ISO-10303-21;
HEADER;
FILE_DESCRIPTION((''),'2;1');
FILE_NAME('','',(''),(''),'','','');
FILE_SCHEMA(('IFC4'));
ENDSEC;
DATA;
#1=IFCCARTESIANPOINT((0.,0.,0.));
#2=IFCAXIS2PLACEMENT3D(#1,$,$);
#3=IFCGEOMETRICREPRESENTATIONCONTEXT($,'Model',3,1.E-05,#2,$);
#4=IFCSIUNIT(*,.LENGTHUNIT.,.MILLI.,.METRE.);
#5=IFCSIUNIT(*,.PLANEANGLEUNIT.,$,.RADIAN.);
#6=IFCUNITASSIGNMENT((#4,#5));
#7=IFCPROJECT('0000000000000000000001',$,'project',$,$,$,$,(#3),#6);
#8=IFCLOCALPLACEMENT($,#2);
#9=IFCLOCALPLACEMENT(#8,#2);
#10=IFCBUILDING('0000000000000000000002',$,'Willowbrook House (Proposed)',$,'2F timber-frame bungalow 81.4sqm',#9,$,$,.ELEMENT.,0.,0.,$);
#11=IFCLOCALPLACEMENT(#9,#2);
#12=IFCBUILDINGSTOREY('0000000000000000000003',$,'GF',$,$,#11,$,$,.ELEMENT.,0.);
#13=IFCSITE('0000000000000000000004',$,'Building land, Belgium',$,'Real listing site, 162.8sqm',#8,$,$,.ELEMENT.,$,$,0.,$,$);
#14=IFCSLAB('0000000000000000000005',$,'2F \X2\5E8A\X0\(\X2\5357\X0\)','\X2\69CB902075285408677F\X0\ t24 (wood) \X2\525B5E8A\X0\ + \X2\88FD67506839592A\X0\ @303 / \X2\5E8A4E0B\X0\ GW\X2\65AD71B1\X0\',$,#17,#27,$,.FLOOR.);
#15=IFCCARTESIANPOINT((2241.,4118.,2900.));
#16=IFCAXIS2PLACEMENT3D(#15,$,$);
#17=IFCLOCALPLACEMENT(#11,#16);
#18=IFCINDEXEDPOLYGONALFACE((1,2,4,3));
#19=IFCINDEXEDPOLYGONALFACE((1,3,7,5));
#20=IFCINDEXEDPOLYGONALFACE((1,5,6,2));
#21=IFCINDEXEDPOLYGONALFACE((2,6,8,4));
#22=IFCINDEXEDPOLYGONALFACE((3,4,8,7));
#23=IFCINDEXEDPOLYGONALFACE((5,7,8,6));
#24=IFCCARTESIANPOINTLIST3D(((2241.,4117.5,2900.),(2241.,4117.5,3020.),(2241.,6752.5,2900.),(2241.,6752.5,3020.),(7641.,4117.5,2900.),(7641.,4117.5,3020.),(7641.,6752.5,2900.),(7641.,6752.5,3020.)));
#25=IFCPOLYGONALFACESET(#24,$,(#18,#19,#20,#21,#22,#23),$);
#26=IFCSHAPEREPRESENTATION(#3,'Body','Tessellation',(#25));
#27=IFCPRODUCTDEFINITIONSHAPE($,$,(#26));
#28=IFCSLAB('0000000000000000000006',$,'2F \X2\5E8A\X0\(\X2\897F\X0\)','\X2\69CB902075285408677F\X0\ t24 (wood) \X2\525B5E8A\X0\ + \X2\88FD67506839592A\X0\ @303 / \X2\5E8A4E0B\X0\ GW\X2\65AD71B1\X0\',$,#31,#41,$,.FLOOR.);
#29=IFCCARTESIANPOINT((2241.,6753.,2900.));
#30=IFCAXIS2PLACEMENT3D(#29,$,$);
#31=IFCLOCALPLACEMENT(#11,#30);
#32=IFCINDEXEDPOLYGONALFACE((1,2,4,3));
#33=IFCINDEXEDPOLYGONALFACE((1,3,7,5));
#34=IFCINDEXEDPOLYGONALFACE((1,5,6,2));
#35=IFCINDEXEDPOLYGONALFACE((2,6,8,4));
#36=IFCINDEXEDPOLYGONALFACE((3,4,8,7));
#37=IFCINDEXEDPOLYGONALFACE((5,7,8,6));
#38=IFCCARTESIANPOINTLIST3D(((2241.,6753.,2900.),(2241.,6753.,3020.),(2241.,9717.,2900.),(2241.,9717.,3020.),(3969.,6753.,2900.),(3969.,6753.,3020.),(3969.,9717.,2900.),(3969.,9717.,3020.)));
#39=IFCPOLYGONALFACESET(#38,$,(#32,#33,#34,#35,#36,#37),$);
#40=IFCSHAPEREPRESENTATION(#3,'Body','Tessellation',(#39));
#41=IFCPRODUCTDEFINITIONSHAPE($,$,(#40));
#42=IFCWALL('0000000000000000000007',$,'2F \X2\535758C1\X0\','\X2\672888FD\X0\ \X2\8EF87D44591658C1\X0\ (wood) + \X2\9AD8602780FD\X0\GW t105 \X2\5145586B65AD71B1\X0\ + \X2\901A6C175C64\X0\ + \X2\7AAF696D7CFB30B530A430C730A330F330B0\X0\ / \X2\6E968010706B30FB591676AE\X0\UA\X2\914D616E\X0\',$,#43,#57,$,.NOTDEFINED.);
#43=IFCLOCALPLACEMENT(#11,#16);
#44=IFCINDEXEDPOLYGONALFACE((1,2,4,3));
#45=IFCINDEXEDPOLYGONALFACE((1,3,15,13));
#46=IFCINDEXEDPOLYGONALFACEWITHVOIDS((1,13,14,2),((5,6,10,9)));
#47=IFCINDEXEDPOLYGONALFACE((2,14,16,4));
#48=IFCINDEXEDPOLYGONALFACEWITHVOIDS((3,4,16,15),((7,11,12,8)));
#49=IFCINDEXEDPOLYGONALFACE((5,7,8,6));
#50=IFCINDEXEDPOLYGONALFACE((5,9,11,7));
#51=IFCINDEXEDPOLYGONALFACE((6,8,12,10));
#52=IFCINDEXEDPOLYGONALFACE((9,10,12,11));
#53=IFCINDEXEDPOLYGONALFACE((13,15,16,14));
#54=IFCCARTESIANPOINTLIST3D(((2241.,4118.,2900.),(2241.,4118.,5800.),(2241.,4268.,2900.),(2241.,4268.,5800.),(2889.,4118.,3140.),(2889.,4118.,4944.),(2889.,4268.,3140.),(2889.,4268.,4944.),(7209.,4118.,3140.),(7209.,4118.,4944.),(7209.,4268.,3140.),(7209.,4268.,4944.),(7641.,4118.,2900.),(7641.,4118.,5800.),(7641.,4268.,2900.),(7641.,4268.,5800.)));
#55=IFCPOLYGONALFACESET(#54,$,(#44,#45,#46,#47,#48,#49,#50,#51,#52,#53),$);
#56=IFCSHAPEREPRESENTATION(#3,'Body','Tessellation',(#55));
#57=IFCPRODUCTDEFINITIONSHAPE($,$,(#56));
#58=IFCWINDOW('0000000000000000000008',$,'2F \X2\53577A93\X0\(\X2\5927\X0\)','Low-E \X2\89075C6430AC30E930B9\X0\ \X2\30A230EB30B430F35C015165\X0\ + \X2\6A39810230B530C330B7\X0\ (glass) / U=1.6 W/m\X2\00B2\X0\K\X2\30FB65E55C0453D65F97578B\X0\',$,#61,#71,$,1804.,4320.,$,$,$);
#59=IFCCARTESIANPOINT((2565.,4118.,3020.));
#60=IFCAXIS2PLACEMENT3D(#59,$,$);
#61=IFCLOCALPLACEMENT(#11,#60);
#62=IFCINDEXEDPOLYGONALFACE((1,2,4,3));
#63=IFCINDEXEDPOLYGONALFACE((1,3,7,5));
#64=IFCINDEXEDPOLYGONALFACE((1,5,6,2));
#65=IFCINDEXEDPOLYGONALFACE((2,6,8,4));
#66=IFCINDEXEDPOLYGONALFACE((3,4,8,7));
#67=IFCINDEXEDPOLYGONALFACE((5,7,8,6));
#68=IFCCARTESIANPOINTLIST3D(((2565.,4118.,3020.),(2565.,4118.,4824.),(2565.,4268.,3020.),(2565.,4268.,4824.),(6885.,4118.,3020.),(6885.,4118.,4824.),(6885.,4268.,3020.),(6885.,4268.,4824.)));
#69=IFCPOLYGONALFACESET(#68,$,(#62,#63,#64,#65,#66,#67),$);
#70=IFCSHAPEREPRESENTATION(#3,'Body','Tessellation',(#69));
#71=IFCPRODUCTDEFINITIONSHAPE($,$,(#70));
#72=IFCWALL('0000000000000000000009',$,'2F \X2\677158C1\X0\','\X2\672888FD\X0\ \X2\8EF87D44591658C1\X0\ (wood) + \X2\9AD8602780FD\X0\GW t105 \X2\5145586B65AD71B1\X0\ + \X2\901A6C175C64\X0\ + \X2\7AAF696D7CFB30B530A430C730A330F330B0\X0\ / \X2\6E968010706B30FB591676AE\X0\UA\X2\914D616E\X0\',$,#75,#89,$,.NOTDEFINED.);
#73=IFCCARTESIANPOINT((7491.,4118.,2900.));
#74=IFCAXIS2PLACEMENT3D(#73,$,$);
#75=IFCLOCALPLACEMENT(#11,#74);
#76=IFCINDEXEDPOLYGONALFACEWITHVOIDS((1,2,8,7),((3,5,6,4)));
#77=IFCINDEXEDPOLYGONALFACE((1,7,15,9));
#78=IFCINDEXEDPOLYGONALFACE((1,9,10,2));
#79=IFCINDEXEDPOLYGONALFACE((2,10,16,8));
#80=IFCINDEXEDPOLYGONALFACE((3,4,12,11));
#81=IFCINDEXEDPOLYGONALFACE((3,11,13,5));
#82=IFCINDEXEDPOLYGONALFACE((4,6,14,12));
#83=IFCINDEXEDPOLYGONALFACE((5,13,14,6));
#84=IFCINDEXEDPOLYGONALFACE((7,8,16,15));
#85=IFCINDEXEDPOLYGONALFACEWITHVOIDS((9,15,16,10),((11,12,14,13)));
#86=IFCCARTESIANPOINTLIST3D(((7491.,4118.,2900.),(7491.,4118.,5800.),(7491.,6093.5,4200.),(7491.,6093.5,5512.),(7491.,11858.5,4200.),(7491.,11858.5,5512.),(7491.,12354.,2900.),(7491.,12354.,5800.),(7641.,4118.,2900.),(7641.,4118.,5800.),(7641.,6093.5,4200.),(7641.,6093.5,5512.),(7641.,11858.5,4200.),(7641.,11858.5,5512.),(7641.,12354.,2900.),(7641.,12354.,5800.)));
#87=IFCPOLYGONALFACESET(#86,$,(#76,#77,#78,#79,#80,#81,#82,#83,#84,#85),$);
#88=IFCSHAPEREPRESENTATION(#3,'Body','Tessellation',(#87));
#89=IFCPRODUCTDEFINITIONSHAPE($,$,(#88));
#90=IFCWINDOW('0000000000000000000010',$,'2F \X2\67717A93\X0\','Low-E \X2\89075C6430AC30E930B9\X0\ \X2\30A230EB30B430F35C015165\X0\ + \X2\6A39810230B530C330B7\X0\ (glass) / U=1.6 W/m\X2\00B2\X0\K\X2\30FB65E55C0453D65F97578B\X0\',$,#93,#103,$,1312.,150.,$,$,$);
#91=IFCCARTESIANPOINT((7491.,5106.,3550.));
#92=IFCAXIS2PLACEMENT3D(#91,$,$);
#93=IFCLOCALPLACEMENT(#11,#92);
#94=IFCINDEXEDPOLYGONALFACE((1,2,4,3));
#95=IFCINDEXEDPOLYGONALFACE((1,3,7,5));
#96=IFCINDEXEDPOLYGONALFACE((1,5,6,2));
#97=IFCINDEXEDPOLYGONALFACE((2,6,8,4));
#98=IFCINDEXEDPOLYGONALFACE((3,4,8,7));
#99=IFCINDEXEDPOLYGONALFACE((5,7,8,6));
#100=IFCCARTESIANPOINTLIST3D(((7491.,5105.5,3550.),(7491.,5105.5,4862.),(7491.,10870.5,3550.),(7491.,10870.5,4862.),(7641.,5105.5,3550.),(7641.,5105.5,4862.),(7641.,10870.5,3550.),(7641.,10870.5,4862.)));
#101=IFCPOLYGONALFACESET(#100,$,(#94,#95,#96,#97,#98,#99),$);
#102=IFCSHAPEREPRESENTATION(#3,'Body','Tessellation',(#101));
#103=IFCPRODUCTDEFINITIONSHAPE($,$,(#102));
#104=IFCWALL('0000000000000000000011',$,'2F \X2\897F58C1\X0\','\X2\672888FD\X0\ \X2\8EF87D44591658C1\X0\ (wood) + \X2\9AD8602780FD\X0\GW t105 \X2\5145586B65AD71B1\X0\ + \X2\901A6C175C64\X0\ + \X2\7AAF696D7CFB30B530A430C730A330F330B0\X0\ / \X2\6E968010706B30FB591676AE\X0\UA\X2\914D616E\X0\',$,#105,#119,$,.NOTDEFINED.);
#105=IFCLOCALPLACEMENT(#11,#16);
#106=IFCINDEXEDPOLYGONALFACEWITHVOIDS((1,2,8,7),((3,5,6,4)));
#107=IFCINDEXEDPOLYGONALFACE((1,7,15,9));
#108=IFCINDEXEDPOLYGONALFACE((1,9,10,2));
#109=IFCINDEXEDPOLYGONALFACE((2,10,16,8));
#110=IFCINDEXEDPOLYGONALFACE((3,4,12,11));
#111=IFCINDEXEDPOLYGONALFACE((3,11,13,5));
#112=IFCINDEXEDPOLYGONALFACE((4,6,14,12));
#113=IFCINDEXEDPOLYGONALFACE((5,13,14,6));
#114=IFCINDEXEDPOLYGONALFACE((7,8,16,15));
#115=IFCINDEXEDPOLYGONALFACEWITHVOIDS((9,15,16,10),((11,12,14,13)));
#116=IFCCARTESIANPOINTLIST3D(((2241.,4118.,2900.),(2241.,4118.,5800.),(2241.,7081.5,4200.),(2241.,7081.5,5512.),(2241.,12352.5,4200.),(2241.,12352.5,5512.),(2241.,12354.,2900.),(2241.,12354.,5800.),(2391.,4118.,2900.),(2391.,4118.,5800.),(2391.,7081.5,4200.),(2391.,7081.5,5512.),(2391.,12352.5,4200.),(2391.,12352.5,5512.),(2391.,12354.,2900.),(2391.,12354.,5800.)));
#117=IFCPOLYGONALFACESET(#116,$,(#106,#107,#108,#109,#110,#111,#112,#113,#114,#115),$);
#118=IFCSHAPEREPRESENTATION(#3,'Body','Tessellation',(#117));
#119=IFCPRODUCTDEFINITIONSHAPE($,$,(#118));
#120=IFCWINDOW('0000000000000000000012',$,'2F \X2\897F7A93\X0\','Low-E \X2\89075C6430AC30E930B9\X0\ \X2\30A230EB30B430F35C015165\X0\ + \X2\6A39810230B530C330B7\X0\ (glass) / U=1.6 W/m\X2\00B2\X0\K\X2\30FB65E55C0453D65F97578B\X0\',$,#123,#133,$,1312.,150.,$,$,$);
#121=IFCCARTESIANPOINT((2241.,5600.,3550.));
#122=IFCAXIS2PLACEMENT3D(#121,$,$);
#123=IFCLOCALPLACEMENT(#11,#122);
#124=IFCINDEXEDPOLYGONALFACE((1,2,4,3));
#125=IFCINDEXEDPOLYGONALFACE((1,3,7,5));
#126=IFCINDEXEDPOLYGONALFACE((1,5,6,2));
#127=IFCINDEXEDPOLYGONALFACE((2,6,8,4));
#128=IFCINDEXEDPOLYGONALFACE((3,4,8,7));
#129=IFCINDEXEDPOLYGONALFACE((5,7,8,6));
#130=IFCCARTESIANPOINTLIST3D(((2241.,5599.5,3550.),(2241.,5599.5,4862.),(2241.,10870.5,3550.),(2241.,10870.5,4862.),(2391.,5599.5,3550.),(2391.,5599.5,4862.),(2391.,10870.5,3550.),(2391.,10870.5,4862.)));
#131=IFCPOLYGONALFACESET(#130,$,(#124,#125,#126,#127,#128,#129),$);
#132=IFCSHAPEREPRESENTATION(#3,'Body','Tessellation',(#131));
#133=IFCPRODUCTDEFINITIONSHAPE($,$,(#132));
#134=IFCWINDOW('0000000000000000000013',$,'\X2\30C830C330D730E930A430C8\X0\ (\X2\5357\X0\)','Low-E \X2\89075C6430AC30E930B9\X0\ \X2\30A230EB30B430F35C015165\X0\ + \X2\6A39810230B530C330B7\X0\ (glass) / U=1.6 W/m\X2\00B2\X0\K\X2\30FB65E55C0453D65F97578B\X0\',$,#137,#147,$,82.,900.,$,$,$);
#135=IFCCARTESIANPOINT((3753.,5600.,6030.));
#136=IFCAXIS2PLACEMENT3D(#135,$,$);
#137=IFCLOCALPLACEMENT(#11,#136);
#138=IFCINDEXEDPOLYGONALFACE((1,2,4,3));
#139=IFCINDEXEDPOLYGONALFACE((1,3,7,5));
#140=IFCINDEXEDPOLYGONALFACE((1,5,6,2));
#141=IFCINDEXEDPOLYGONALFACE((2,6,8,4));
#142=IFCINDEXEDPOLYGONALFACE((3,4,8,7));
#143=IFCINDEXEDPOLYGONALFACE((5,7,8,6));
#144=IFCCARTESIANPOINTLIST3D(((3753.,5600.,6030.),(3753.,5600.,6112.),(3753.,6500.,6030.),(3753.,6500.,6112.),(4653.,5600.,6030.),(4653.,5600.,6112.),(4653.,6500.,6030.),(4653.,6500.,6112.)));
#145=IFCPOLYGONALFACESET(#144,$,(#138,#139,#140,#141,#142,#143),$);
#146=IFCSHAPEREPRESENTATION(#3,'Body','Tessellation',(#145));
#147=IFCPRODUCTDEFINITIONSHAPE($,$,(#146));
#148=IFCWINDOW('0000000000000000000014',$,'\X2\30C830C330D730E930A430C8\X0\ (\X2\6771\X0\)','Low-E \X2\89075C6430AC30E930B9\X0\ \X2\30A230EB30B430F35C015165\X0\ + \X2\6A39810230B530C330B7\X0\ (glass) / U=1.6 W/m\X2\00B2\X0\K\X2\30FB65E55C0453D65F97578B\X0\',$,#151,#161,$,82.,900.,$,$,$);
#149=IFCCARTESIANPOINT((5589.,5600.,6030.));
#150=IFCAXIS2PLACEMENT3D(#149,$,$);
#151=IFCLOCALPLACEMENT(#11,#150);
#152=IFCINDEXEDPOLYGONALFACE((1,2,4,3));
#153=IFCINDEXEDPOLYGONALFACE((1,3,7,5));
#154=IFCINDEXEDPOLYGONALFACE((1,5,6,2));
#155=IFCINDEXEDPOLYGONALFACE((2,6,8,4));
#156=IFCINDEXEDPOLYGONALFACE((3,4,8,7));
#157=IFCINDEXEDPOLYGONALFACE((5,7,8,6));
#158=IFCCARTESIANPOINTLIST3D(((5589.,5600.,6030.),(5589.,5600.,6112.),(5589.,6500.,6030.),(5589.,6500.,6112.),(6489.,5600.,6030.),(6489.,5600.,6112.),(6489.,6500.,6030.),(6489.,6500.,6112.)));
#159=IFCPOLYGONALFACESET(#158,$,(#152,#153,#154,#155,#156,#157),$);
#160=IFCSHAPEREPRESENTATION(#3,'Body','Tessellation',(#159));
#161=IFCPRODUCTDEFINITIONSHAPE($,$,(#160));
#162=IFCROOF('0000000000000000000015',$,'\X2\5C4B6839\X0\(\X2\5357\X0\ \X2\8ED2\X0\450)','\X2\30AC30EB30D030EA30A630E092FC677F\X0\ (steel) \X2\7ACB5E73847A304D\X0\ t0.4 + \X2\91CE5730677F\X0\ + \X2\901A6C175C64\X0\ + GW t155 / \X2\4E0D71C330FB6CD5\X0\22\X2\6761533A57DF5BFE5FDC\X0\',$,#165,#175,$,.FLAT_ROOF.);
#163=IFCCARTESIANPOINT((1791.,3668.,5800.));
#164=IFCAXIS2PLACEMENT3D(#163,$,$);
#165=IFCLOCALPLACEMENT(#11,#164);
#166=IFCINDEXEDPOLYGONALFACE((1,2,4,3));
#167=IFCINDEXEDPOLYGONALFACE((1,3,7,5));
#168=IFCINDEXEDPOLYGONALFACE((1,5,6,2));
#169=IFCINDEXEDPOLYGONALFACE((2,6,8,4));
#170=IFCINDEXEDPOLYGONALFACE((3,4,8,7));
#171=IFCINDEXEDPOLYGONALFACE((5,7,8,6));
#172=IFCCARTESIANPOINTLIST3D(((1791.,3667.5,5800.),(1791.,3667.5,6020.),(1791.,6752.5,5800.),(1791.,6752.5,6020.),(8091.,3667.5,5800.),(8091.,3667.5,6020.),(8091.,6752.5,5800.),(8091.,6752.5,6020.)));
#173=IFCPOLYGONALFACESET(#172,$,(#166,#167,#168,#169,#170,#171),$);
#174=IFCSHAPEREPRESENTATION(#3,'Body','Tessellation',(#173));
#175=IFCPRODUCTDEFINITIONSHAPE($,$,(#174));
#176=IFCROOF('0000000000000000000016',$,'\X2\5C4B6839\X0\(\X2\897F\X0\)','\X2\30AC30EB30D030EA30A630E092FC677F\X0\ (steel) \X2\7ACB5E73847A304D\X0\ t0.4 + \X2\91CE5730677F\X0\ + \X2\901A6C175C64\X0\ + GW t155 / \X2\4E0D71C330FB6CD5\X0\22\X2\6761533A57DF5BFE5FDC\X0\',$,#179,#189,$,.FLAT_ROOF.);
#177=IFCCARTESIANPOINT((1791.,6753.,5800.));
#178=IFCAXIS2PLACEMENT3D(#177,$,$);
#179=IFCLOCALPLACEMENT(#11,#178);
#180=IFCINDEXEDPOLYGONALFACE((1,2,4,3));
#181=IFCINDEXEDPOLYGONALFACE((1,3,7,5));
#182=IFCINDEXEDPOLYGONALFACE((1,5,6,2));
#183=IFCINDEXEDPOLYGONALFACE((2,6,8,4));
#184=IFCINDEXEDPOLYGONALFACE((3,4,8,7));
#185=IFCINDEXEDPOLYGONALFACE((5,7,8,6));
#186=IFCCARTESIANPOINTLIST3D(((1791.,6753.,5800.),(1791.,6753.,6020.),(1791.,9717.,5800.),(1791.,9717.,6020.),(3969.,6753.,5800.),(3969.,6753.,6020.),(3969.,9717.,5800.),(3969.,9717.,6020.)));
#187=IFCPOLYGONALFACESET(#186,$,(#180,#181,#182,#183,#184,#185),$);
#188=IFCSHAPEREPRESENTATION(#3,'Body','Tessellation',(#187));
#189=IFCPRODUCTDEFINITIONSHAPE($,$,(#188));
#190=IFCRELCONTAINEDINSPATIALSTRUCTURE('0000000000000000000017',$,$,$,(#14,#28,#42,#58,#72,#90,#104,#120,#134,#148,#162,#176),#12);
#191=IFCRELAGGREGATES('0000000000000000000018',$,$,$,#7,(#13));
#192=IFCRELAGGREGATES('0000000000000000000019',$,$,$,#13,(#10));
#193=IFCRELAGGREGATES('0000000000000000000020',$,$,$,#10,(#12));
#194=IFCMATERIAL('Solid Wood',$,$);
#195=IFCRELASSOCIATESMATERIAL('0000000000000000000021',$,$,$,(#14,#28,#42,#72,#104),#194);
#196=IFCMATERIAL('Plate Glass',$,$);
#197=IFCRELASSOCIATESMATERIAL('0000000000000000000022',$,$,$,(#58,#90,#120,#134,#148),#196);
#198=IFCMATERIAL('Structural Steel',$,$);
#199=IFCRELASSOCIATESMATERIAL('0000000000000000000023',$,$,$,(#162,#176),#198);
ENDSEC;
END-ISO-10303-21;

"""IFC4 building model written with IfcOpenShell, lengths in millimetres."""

from ifc_helpers import new_model, si_unit, frame, frame_2d, origin, place, context, project, spatial, rectangle, extrude, material, element, fill, save


model = new_model("IFC4")

# Units and contexts
model_context = context("Model", 3, precision=1e-05, world=origin())
ifc_project = project(units=[si_unit("LENGTHUNIT", "METRE", prefix="MILLI"), si_unit("PLANEANGLEUNIT", "RADIAN")], contexts=[model_context])

# Site, building, storey
site_placement = place(None, origin())
site = spatial("IfcSite", under=ifc_project, at=site_placement, Name="Building land, Belgium", ObjectType="Real listing site, 162.8sqm", CompositionType="ELEMENT", RefElevation=0.0)
building_placement = place(site_placement, origin())
building = spatial("IfcBuilding", under=site, at=building_placement, Name="Willowbrook House (Proposed)", ObjectType="2F timber-frame bungalow 81.4sqm", CompositionType="ELEMENT", ElevationOfRefHeight=0.0, ElevationOfTerrain=0.0)
storey_placement = place(building_placement, origin())
storey = spatial("IfcBuildingStorey", under=building, at=storey_placement, Name="GF", CompositionType="ELEMENT", Elevation=0.0)

# Slabs
ifc_material_1 = material(Name="Solid Wood")
slab_1_placement = place(storey_placement, frame((2241.0, 4118.0, 2900.0)))
element("IfcSlab", 1, at=slab_1_placement, inside=storey, material=ifc_material_1, Name="2F 床(南)", Description="構造用合板 t24 (wood) 剛床 + 製材根太 @303 / 床下 GW断熱", PredefinedType="FLOOR", context=model_context, shape_type="SweptSolid", body=[
    extrude(rectangle(XDim=5400.0, YDim=2635.0, at=frame_2d((2700.0, 1317.0))), frame((2241.0, 4118.0, 2900.0)), (0.0, 0.0, 1.0), 120.0),
])
slab_2_placement = place(storey_placement, frame((2241.0, 6753.0, 2900.0)))
element("IfcSlab", 2, at=slab_2_placement, inside=storey, material=ifc_material_1, Name="2F 床(西)", Description="構造用合板 t24 (wood) 剛床 + 製材根太 @303 / 床下 GW断熱", PredefinedType="FLOOR", context=model_context, shape_type="SweptSolid", body=[
    extrude(rectangle(XDim=1728.0, YDim=2964.0, at=frame_2d((864.0, 1482.0))), frame((2241.0, 6753.0, 2900.0)), (0.0, 0.0, 1.0), 120.0),
])

# Walls, openings, windows
wall_1_placement = place(storey_placement, frame((2241.0, 4118.0, 2900.0)))
wall_1 = element("IfcWall", 3, at=wall_1_placement, inside=storey, material=ifc_material_1, Name="2F 南壁", Description="木製 軸組外壁 (wood) + 高性能GW t105 充填断熱 + 通気層 + 窯業系サイディング / 準耐火・外皮UA配慮", PredefinedType="NOTDEFINED", context=model_context, shape_type="SweptSolid", body=[
    extrude(rectangle(XDim=5400.0, YDim=150.0, at=frame_2d((2700.0, 75.0))), frame((2241.0, 4118.0, 2900.0)), (0.0, 0.0, 1.0), 2900.0),
])
opening_1_placement = place(storey_placement, frame((2565.0, 4118.0, 3020.0)))
opening_1 = element("IfcOpeningElement", 4, at=opening_1_placement, cuts=wall_1, PredefinedType="NOTDEFINED", context=model_context, shape_type="SweptSolid", body=[
    extrude(rectangle(XDim=4320.0, YDim=150.0, at=frame_2d((2160.0, 75.0))), frame((2565.0, 4118.0, 3020.0)), (0.0, 0.0, 1.0), 1804.0),
])
ifc_material_2 = material(Name="Plate Glass")
window_1_placement = place(storey_placement, frame((2565.0, 4118.0, 3020.0)))
window_1 = element("IfcWindow", 5, at=window_1_placement, inside=storey, material=ifc_material_2, Name="2F 南窓(大)", Description="Low-E 複層ガラス アルゴン封入 + 樹脂サッシ (glass) / U=1.6 W/m²K・日射取得型", OverallHeight=1804.0, OverallWidth=4320.0, context=model_context, shape_type="SweptSolid", body=[
    extrude(rectangle(XDim=4320.0, YDim=150.0, at=frame_2d((2160.0, 75.0))), frame((2565.0, 4118.0, 3020.0)), (0.0, 0.0, 1.0), 1804.0),
])
fill(opening_1, window_1)
wall_2_placement = place(storey_placement, frame((7491.0, 4118.0, 2900.0)))
wall_2 = element("IfcWall", 6, at=wall_2_placement, inside=storey, material=ifc_material_1, Name="2F 東壁", Description="木製 軸組外壁 (wood) + 高性能GW t105 充填断熱 + 通気層 + 窯業系サイディング / 準耐火・外皮UA配慮", PredefinedType="NOTDEFINED", context=model_context, shape_type="SweptSolid", body=[
    extrude(rectangle(XDim=150.0, YDim=8236.0, at=frame_2d((75.0, 4118.0))), frame((7491.0, 4118.0, 2900.0)), (0.0, 0.0, 1.0), 2900.0),
])
opening_2_placement = place(storey_placement, frame((7491.0, 5106.0, 3550.0)))
opening_2 = element("IfcOpeningElement", 7, at=opening_2_placement, cuts=wall_2, PredefinedType="NOTDEFINED", context=model_context, shape_type="SweptSolid", body=[
    extrude(rectangle(XDim=150.0, YDim=5765.0, at=frame_2d((75.0, 2882.0))), frame((7491.0, 5106.0, 3550.0)), (0.0, 0.0, 1.0), 1312.0),
])
window_2_placement = place(storey_placement, frame((7491.0, 5106.0, 3550.0)))
window_2 = element("IfcWindow", 8, at=window_2_placement, inside=storey, material=ifc_material_2, Name="2F 東窓", Description="Low-E 複層ガラス アルゴン封入 + 樹脂サッシ (glass) / U=1.6 W/m²K・日射取得型", OverallHeight=1312.0, OverallWidth=150.0, context=model_context, shape_type="SweptSolid", body=[
    extrude(rectangle(XDim=150.0, YDim=5765.0, at=frame_2d((75.0, 2882.0))), frame((7491.0, 5106.0, 3550.0)), (0.0, 0.0, 1.0), 1312.0),
])
fill(opening_2, window_2)
wall_3_placement = place(storey_placement, frame((2241.0, 4118.0, 2900.0)))
wall_3 = element("IfcWall", 9, at=wall_3_placement, inside=storey, material=ifc_material_1, Name="2F 西壁", Description="木製 軸組外壁 (wood) + 高性能GW t105 充填断熱 + 通気層 + 窯業系サイディング / 準耐火・外皮UA配慮", PredefinedType="NOTDEFINED", context=model_context, shape_type="SweptSolid", body=[
    extrude(rectangle(XDim=150.0, YDim=8236.0, at=frame_2d((75.0, 4118.0))), frame((2241.0, 4118.0, 2900.0)), (0.0, 0.0, 1.0), 2900.0),
])
opening_3_placement = place(storey_placement, frame((2241.0, 5600.0, 3550.0)))
opening_3 = element("IfcOpeningElement", 10, at=opening_3_placement, cuts=wall_3, PredefinedType="NOTDEFINED", context=model_context, shape_type="SweptSolid", body=[
    extrude(rectangle(XDim=150.0, YDim=5271.0, at=frame_2d((75.0, 2635.0))), frame((2241.0, 5600.0, 3550.0)), (0.0, 0.0, 1.0), 1312.0),
])
window_3_placement = place(storey_placement, frame((2241.0, 5600.0, 3550.0)))
window_3 = element("IfcWindow", 11, at=window_3_placement, inside=storey, material=ifc_material_2, Name="2F 西窓", Description="Low-E 複層ガラス アルゴン封入 + 樹脂サッシ (glass) / U=1.6 W/m²K・日射取得型", OverallHeight=1312.0, OverallWidth=150.0, context=model_context, shape_type="SweptSolid", body=[
    extrude(rectangle(XDim=150.0, YDim=5271.0, at=frame_2d((75.0, 2635.0))), frame((2241.0, 5600.0, 3550.0)), (0.0, 0.0, 1.0), 1312.0),
])
fill(opening_3, window_3)

# Windows
window_4_placement = place(storey_placement, frame((3753.0, 5600.0, 6030.0)))
element("IfcWindow", 12, at=window_4_placement, inside=storey, material=ifc_material_2, Name="トップライト (南)", Description="Low-E 複層ガラス アルゴン封入 + 樹脂サッシ (glass) / U=1.6 W/m²K・日射取得型", OverallHeight=82.0, OverallWidth=900.0, context=model_context, shape_type="SweptSolid", body=[
    extrude(rectangle(XDim=900.0, YDim=900.0, at=frame_2d((450.0, 450.0))), frame((3753.0, 5600.0, 6030.0)), (0.0, 0.0, 1.0), 82.0),
])
window_5_placement = place(storey_placement, frame((5589.0, 5600.0, 6030.0)))
element("IfcWindow", 13, at=window_5_placement, inside=storey, material=ifc_material_2, Name="トップライト (東)", Description="Low-E 複層ガラス アルゴン封入 + 樹脂サッシ (glass) / U=1.6 W/m²K・日射取得型", OverallHeight=82.0, OverallWidth=900.0, context=model_context, shape_type="SweptSolid", body=[
    extrude(rectangle(XDim=900.0, YDim=900.0, at=frame_2d((450.0, 450.0))), frame((5589.0, 5600.0, 6030.0)), (0.0, 0.0, 1.0), 82.0),
])

# Roofs
ifc_material_3 = material(Name="Structural Steel")
roof_1_placement = place(storey_placement, frame((1791.0, 3668.0, 5800.0)))
element("IfcRoof", 14, at=roof_1_placement, inside=storey, material=ifc_material_3, Name="屋根(南 軒450)", Description="ガルバリウム鋼板 (steel) 立平葺き t0.4 + 野地板 + 通気層 + GW t155 / 不燃・法22条区域対応", PredefinedType="FLAT_ROOF", context=model_context, shape_type="SweptSolid", body=[
    extrude(rectangle(XDim=6300.0, YDim=3085.0, at=frame_2d((3150.0, 1542.0))), frame((1791.0, 3668.0, 5800.0)), (0.0, 0.0, 1.0), 220.0),
])
roof_2_placement = place(storey_placement, frame((1791.0, 6753.0, 5800.0)))
element("IfcRoof", 15, at=roof_2_placement, inside=storey, material=ifc_material_3, Name="屋根(西)", Description="ガルバリウム鋼板 (steel) 立平葺き t0.4 + 野地板 + 通気層 + GW t155 / 不燃・法22条区域対応", PredefinedType="FLAT_ROOF", context=model_context, shape_type="SweptSolid", body=[
    extrude(rectangle(XDim=2178.0, YDim=2964.0, at=frame_2d((1089.0, 1482.0))), frame((1791.0, 6753.0, 5800.0)), (0.0, 0.0, 1.0), 220.0),
])

save(model, "model.ifc")
